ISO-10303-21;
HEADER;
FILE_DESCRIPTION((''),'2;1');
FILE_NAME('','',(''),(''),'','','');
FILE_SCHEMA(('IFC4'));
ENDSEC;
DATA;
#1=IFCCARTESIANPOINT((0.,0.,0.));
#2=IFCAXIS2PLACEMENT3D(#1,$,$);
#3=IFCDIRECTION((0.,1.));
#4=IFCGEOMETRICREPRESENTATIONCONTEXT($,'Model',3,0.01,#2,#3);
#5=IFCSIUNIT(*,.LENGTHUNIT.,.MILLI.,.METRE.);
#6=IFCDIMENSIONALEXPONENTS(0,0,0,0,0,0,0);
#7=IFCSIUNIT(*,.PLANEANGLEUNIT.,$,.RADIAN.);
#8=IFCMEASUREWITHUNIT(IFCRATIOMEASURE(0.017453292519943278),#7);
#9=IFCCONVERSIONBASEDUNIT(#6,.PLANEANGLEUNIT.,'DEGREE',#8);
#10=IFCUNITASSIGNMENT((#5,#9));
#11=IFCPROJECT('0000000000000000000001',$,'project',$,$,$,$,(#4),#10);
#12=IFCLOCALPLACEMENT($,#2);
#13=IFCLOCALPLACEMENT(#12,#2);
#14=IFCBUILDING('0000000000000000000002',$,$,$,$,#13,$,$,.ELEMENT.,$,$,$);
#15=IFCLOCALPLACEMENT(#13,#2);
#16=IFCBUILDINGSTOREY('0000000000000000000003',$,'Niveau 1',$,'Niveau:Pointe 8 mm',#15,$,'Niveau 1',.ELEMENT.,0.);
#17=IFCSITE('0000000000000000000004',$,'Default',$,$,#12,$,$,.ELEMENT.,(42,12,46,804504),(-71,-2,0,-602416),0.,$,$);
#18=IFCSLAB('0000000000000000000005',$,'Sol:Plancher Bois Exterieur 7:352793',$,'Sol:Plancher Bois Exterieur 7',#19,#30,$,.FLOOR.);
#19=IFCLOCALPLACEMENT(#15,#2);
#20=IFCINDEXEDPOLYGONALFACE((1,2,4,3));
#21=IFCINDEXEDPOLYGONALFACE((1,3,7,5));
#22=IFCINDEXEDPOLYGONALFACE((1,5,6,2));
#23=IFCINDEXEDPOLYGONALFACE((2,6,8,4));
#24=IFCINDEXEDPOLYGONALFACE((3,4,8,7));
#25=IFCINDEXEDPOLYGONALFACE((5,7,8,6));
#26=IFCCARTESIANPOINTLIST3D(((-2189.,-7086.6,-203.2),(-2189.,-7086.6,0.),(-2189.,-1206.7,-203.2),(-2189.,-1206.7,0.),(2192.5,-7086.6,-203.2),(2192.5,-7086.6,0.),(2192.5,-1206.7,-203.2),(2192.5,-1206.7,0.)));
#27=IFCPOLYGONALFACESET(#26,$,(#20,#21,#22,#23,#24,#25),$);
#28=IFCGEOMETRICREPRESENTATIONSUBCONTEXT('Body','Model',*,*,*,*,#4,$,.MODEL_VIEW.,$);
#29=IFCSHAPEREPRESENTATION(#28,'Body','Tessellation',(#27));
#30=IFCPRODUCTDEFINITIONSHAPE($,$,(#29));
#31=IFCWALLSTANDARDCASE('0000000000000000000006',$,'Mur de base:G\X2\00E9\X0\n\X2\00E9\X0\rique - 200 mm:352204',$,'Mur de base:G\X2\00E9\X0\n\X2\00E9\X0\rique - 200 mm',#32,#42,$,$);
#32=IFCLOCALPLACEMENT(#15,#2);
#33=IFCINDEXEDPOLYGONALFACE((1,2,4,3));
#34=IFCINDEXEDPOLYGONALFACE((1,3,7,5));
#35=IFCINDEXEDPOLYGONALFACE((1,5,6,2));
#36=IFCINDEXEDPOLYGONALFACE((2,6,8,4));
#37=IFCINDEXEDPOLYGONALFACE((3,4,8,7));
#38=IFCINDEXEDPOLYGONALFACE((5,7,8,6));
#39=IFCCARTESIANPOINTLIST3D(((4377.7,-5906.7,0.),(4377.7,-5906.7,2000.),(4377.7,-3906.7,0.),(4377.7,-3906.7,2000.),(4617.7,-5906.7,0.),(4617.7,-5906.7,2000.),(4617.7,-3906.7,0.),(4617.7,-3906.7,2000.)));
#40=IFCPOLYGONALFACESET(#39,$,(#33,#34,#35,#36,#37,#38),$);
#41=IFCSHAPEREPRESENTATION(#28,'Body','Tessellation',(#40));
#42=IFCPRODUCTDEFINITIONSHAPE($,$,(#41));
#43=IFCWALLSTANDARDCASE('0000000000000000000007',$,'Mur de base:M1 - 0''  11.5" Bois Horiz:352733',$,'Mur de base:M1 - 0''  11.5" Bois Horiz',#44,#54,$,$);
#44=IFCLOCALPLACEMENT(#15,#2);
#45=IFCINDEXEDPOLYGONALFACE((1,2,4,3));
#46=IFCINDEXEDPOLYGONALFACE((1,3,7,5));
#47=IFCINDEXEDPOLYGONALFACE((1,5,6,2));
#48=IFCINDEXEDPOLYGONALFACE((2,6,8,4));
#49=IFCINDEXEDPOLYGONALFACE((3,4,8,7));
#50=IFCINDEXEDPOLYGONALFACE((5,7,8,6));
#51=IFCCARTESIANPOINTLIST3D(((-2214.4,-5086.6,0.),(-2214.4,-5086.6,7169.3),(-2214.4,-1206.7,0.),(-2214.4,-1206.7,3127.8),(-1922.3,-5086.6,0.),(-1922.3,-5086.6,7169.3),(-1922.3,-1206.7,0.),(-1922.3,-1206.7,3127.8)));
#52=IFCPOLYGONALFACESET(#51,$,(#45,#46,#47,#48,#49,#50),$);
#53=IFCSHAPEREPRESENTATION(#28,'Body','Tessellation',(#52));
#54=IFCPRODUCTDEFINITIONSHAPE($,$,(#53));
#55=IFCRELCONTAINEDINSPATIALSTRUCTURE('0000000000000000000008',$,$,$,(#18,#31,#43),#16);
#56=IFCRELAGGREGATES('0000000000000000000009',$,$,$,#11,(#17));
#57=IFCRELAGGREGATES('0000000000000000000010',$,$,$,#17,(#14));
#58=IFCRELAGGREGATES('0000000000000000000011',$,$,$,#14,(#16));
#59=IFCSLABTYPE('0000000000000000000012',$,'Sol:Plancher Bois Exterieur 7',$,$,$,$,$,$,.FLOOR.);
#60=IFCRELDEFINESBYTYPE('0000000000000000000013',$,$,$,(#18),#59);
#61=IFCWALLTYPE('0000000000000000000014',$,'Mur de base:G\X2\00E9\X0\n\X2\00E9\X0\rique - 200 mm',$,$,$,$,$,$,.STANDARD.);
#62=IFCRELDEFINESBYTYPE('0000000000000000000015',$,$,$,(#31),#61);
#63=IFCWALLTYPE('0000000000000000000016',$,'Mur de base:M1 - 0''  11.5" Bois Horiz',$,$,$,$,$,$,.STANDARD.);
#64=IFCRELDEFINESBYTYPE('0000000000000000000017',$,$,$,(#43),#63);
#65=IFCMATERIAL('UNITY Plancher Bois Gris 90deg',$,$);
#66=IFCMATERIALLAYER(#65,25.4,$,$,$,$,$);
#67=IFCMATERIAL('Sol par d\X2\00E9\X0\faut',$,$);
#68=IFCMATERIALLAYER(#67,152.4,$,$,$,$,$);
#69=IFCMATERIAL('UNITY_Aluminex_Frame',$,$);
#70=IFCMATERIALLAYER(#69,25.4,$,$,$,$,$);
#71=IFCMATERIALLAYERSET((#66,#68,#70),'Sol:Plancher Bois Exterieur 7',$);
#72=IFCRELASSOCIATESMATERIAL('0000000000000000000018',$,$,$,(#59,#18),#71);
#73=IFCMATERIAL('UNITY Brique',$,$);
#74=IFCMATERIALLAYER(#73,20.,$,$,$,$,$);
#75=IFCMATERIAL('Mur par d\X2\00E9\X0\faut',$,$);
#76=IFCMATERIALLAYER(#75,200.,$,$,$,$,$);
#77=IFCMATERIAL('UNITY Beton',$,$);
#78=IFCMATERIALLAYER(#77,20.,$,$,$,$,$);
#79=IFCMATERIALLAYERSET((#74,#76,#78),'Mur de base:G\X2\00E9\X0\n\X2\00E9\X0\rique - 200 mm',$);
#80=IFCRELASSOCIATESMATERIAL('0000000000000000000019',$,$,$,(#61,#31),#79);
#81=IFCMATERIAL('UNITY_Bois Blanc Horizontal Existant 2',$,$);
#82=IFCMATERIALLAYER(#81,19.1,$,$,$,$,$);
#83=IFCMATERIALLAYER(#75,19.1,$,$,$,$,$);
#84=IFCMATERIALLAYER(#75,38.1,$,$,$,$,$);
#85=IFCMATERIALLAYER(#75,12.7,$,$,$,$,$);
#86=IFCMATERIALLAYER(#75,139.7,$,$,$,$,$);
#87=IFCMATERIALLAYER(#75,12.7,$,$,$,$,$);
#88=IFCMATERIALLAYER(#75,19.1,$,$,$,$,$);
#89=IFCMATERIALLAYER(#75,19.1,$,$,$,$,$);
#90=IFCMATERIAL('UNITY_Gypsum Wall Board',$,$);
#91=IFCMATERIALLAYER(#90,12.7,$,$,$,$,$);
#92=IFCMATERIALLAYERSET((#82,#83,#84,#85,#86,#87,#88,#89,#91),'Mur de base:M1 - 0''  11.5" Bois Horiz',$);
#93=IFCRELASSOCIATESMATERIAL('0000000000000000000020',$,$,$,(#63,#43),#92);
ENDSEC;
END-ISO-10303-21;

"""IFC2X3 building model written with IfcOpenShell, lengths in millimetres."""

from ifc_helpers import new_model, entity, si_unit, converted_unit, direction, frame, frame_2d, origin, place, context, subcontext, project, spatial, polyline, rectangle, extrude, clip, bounded_halfspace, material, layer, layer_set, layer_usage, type_object, element, save


model = new_model("IFC2X3")

# Units and contexts
model_context = context("Model", 3, precision=0.01, world=origin(), true_north=direction((0.0, 1.0)))
body_context = subcontext(model_context, "Body", "Model", "MODEL_VIEW")
ifc_project = project(units=[si_unit("LENGTHUNIT", "METRE", prefix="MILLI"), converted_unit("PLANEANGLEUNIT", "DEGREE", entity("IfcRatioMeasure", 0.017453292519943278), si_unit("PLANEANGLEUNIT", "RADIAN"), dimensions=[0, 0, 0, 0, 0, 0, 0])], contexts=[model_context])

# Site, building, storey
site_placement = place(None, origin())
site = spatial("IfcSite", under=ifc_project, at=site_placement, Name="Default", CompositionType="ELEMENT", RefLatitude=(42, 12, 46, 804504), RefLongitude=(-71, -2, 0, -602416), RefElevation=0.0)
building_placement = place(site_placement, origin())
building = spatial("IfcBuilding", under=site, at=building_placement, CompositionType="ELEMENT")
storey_placement = place(building_placement, origin())
storey = spatial("IfcBuildingStorey", under=building, at=storey_placement, Name="Niveau 1", ObjectType="Niveau:Pointe 8 mm", LongName="Niveau 1", CompositionType="ELEMENT", Elevation=0.0)

# Slab
ifc_material_1 = material(Name="UNITY Plancher Bois Gris 90deg")
ifc_layer_1 = layer(ifc_material_1, 25.4)
ifc_material_2 = material(Name="Sol par défaut")
ifc_layer_2 = layer(ifc_material_2, 152.4)
ifc_material_3 = material(Name="UNITY_Aluminex_Frame")
ifc_layer_3 = layer(ifc_material_3, 25.4)
ifc_layer_set_1 = layer_set([ifc_layer_1, ifc_layer_2, ifc_layer_3], Name="Sol:Plancher Bois Exterieur 7")
ifc_layer_usage_1 = layer_usage(ifc_layer_set_1, "AXIS3", "POSITIVE", 0.0)
slab_type = type_object("IfcSlabType", Name="Sol:Plancher Bois Exterieur 7", PredefinedType="FLOOR", material=ifc_layer_set_1)
slab_placement = place(storey_placement, origin())
element("IfcSlab", 1, at=slab_placement, inside=storey, type_object=slab_type, material=ifc_layer_usage_1, Name="Sol:Plancher Bois Exterieur 7:352793", ObjectType="Sol:Plancher Bois Exterieur 7", PredefinedType="FLOOR", context=body_context, shape_type="SweptSolid", body=[
    extrude(rectangle(XDim=5879.8, YDim=4381.5, at=frame_2d((0.0, 0.0), x_axis=(1.0, 0.0))), frame((1.8, -4146.6, 0.0), z_axis=(0.0, 0.0, -1.0), x_axis=(0.0, 1.0, 0.0)), (0.0, 0.0, 1.0), 203.2),
])

# Wall
ifc_material_4 = material(Name="UNITY Brique")
ifc_layer_4 = layer(ifc_material_4, 20.0)
ifc_material_5 = material(Name="Mur par défaut")
ifc_layer_5 = layer(ifc_material_5, 200.0)
ifc_material_6 = material(Name="UNITY Beton")
ifc_layer_6 = layer(ifc_material_6, 20.0)
ifc_layer_set_2 = layer_set([ifc_layer_4, ifc_layer_5, ifc_layer_6], Name="Mur de base:Générique - 200 mm")
ifc_layer_usage_2 = layer_usage(ifc_layer_set_2, "AXIS2", "NEGATIVE", 120.0)
wall_type_1 = type_object("IfcWallType", Name="Mur de base:Générique - 200 mm", PredefinedType="STANDARD", material=ifc_layer_set_2)
wall_1_placement = place(storey_placement, frame((4497.7, -3906.7, 0.0), z_axis=(0.0, 0.0, 1.0), x_axis=(0.0, -1.0, 0.0)))
element("IfcWallStandardCase", 2, at=wall_1_placement, inside=storey, type_object=wall_type_1, material=ifc_layer_usage_2, Name="Mur de base:Générique - 200 mm:352204", ObjectType="Mur de base:Générique - 200 mm", context=body_context, shape_type="SweptSolid", body=[
    extrude(rectangle(XDim=2000.0, YDim=240.0, at=frame_2d((1000.0, 0.0), x_axis=(-1.0, 0.0))), origin(), (0.0, 0.0, 1.0), 2000.0),
])

# Shared definitions
ifc_material_7 = material(Name="UNITY_Bois Blanc Horizontal Existant 2")
ifc_layer_7 = layer(ifc_material_7, 19.1)
ifc_layer_8 = layer(ifc_material_5, 19.1)
ifc_layer_9 = layer(ifc_material_5, 38.1)
ifc_layer_10 = layer(ifc_material_5, 12.7)
ifc_layer_11 = layer(ifc_material_5, 139.7)
ifc_layer_12 = layer(ifc_material_5, 12.7)
ifc_layer_13 = layer(ifc_material_5, 19.1)
ifc_layer_14 = layer(ifc_material_5, 19.1)
ifc_material_8 = material(Name="UNITY_Gypsum Wall Board")
ifc_layer_15 = layer(ifc_material_8, 12.7)
ifc_layer_set_3 = layer_set([ifc_layer_7, ifc_layer_8, ifc_layer_9, ifc_layer_10, ifc_layer_11, ifc_layer_12, ifc_layer_13, ifc_layer_14, ifc_layer_15], Name="Mur de base:M1 - 0'  11.5\" Bois Horiz")
wall_type_2 = type_object("IfcWallType", Name="Mur de base:M1 - 0'  11.5\" Bois Horiz", PredefinedType="STANDARD", material=ifc_layer_set_3)

# Wall
ifc_layer_usage_3 = layer_usage(ifc_layer_set_3, "AXIS2", "NEGATIVE", 146.1)
wall_2_placement = place(storey_placement, frame((-2068.3, -5086.6, 0.0), z_axis=(0.0, 0.0, 1.0), x_axis=(0.0, 1.0, 0.0)))
element("IfcWallStandardCase", 3, at=wall_2_placement, inside=storey, type_object=wall_type_2, material=ifc_layer_usage_3, Name="Mur de base:M1 - 0'  11.5\" Bois Horiz:352733", ObjectType="Mur de base:M1 - 0'  11.5\" Bois Horiz", context=body_context, shape_type="Clipping", body=[
    clip(extrude(rectangle(XDim=3879.8, YDim=292.1, at=frame_2d((1939.9, 0.0), x_axis=(-1.0, 0.0))), origin(), (0.0, 0.0, 1.0), 7169.3), bounded_halfspace(frame((0.0, -146.0, 7169.3), z_axis=(0.721387, 0.0, 0.692532), x_axis=(0.0, 1.0, 0.0)), False, frame((0.0, -146.0, 7169.3)), polyline([(0.0, 0.0), (292.1, 0.0), (3879.8, 0.0), (3879.8, 292.1), (0.0, 292.1), (0.0, 0.0)]))),
])

save(model, "model.ifc")
